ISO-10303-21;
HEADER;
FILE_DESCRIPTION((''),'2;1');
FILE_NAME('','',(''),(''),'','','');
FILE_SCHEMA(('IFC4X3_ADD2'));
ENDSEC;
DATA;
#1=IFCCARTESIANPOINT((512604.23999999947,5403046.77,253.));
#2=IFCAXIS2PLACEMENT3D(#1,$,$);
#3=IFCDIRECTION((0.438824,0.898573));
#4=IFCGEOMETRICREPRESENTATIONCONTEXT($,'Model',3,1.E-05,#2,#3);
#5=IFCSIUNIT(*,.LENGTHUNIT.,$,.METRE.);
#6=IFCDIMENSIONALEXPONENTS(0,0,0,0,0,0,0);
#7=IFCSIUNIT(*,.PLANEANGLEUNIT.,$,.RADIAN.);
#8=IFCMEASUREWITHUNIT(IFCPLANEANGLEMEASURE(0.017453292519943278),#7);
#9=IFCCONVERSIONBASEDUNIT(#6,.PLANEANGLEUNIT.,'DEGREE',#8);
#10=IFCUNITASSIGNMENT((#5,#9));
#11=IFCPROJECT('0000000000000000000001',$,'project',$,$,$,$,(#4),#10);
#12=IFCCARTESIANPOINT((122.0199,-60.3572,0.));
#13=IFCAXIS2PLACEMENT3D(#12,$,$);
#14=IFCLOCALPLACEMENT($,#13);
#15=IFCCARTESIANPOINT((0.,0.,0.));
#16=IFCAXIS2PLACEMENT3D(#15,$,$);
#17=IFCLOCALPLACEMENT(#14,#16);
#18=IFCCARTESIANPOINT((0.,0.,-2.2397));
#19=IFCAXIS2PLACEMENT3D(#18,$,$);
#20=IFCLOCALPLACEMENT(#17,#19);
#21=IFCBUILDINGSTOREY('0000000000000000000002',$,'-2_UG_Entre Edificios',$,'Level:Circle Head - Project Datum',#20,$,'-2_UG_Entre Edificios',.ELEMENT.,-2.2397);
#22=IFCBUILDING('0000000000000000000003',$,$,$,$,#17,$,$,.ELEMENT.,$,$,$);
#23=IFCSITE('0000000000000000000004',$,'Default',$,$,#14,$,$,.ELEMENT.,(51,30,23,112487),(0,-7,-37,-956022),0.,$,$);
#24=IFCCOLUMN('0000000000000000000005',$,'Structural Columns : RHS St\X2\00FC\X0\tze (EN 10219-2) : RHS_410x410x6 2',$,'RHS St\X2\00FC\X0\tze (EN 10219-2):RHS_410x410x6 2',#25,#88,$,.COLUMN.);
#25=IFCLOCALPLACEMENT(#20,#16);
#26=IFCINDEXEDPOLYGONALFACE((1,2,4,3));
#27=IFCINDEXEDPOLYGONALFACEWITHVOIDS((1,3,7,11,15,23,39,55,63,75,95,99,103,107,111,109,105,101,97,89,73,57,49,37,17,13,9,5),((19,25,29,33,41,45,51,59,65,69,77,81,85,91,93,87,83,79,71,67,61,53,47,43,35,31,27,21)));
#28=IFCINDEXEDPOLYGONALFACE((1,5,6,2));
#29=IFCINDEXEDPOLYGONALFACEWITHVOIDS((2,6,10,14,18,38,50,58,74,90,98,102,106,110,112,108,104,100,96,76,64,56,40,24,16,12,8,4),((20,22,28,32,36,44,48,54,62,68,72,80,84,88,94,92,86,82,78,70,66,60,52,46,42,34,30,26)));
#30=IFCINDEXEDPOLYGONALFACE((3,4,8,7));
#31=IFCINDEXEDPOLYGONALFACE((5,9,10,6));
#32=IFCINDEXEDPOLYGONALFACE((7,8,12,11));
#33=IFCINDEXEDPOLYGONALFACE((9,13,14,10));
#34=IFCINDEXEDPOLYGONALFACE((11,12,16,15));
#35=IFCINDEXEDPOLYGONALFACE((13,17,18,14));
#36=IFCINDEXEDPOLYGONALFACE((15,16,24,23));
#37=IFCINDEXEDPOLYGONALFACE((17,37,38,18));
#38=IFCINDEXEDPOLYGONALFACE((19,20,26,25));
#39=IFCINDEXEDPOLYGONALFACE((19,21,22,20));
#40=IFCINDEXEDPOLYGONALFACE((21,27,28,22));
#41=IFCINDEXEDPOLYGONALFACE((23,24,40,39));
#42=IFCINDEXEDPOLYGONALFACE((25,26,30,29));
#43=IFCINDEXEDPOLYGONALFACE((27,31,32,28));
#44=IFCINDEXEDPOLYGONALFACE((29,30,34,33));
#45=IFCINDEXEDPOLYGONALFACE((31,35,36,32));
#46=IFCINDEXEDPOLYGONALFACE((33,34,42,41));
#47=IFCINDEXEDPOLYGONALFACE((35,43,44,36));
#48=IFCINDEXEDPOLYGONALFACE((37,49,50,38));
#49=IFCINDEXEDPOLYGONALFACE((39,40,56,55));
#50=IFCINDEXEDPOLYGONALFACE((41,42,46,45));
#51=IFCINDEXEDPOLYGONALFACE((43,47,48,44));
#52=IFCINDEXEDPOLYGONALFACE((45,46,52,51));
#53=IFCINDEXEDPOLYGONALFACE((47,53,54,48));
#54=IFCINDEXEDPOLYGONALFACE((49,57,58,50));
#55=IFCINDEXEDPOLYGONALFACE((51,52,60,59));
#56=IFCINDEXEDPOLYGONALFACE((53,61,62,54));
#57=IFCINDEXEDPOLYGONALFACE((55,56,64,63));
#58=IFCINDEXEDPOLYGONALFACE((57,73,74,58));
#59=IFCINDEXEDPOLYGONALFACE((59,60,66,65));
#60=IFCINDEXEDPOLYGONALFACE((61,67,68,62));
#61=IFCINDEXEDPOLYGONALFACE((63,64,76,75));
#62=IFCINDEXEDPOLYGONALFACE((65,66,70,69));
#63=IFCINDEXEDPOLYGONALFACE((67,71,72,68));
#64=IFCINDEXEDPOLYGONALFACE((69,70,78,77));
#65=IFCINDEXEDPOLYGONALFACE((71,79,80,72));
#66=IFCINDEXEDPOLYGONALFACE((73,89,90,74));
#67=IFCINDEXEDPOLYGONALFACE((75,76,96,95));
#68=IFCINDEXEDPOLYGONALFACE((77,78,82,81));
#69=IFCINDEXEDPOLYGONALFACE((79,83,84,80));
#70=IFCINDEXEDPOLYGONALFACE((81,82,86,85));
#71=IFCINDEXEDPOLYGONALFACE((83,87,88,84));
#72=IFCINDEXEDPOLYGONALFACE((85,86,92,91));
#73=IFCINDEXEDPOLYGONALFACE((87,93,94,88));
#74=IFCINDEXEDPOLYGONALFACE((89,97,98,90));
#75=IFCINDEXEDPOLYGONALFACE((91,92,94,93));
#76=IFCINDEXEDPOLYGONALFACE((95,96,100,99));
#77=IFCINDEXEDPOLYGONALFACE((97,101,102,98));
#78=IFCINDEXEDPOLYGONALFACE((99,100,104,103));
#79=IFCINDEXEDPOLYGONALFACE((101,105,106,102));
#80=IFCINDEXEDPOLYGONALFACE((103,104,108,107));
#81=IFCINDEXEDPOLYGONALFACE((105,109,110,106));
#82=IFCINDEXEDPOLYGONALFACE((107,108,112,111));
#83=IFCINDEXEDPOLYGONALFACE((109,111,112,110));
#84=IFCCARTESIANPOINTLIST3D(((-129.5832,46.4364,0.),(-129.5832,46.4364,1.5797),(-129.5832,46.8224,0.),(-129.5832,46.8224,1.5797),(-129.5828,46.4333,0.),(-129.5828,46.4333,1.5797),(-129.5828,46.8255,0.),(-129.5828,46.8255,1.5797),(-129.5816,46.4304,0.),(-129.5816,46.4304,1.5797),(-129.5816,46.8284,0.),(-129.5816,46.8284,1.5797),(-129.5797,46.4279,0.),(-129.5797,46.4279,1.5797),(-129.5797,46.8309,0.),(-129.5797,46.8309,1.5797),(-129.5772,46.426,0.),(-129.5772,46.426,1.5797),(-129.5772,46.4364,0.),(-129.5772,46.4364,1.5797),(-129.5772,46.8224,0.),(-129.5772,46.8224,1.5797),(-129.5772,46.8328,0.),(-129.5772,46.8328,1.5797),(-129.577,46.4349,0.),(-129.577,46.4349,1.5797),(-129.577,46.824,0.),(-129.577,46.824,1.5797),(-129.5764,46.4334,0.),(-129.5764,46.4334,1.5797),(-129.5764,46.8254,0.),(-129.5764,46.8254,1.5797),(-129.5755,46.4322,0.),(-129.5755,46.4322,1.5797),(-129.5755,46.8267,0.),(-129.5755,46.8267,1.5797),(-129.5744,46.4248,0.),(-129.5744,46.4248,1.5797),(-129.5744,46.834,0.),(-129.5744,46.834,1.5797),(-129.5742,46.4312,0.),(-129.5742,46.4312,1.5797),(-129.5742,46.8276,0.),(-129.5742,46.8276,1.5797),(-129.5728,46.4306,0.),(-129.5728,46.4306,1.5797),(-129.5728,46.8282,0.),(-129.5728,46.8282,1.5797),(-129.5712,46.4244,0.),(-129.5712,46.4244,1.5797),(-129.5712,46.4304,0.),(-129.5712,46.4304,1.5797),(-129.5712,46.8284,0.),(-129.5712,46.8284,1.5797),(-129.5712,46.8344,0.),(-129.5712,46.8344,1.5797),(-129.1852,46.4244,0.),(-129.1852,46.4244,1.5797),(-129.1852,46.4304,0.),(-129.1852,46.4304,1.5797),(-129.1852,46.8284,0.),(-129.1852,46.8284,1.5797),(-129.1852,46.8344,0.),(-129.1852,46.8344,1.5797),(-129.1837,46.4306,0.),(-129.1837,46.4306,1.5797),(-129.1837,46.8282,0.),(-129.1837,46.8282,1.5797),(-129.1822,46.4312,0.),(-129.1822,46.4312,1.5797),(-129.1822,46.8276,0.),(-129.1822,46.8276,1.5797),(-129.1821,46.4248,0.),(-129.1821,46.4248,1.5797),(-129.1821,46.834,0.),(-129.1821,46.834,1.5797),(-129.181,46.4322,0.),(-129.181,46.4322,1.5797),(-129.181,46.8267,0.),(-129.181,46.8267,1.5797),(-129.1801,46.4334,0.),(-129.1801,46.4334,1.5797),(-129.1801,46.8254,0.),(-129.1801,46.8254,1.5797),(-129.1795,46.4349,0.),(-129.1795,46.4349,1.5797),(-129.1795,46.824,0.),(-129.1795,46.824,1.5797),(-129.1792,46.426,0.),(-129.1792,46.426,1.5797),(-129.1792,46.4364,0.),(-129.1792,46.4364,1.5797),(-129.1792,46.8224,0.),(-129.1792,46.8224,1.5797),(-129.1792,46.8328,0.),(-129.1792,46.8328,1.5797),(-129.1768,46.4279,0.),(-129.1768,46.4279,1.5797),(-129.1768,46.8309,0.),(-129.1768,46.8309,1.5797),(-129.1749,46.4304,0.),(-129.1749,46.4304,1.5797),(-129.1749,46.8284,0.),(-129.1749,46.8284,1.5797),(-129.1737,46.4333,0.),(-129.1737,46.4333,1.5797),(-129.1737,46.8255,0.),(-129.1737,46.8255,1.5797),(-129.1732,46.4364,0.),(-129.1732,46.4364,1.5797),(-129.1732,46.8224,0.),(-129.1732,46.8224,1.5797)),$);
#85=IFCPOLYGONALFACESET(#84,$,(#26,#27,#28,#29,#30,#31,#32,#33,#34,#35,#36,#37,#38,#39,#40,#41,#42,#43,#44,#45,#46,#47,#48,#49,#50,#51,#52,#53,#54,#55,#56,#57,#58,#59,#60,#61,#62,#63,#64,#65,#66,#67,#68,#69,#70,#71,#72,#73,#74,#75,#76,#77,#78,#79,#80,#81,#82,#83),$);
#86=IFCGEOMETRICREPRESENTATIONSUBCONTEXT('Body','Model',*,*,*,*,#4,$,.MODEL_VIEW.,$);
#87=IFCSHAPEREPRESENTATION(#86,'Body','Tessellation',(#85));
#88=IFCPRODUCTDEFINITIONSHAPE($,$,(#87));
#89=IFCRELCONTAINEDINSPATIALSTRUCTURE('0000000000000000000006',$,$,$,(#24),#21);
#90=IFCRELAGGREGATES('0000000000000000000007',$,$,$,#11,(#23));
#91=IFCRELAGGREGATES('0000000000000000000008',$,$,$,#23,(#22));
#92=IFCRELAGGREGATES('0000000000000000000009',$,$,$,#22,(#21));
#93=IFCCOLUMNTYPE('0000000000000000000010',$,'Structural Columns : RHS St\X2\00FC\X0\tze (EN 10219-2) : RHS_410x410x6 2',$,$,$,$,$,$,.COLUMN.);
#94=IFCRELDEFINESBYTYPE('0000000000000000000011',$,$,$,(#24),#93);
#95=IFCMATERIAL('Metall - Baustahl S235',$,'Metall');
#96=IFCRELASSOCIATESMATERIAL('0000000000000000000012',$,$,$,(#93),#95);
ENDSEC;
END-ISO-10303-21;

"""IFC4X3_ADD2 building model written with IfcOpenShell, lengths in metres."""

from ifc_helpers import new_model, entity, si_unit, converted_unit, direction, frame, frame_2d, origin, place, context, subcontext, project, spatial, polyline, circle_curve, parameter, trimmed, segment, composite_curve, outline, extrude, source, transform, mapped, material, material_profile, profile_set, type_object, type_shapes, element, save


model = new_model("IFC4X3_ADD2")

# Units and contexts
model_context = context("Model", 3, precision=1e-05, world=frame((512604.23999999947, 5403046.77, 253.0)), true_north=direction((0.438824, 0.898573)))
body_context = subcontext(model_context, "Body", "Model", "MODEL_VIEW")
ifc_project = project(units=[si_unit("LENGTHUNIT", "METRE"), converted_unit("PLANEANGLEUNIT", "DEGREE", entity("IfcPlaneAngleMeasure", 0.017453292519943278), si_unit("PLANEANGLEUNIT", "RADIAN"), dimensions=[0, 0, 0, 0, 0, 0, 0])], contexts=[model_context])

# Site, building, storey
site_placement = place(None, frame((122.0199, -60.3572, 0.0)))
site = spatial("IfcSite", under=ifc_project, at=site_placement, Name="Default", CompositionType="ELEMENT", RefLatitude=(51, 30, 23, 112487), RefLongitude=(0, -7, -37, -956022), RefElevation=0.0)
building_placement = place(site_placement, origin())
building = spatial("IfcBuilding", under=site, at=building_placement, CompositionType="ELEMENT")
storey_placement = place(building_placement, frame((0.0, 0.0, -2.2397)))
storey = spatial("IfcBuildingStorey", under=building, at=storey_placement, Name="-2_UG_Entre Edificios", ObjectType="Level:Circle Head - Project Datum", LongName="-2_UG_Entre Edificios", CompositionType="ELEMENT", Elevation=-2.2397)

# Column
ifc_material_1 = material(Name="Metall - Baustahl S235", Category="Metall")
ifc_material_profile_1 = material_profile(ifc_material_1, outline(composite_curve([segment(polyline([(-0.193, -0.205), (0.193, -0.205)]), True, "CONTINUOUS"), segment(trimmed(circle_curve(frame_2d((0.193, -0.193), x_axis=(-1.0, 0.0)), 0.012), [parameter(90.0)], [parameter(180.0)], True, "PARAMETER"), True, "CONTINUOUS"), segment(polyline([(0.205, -0.193), (0.205, 0.193)]), True, "CONTINUOUS"), segment(trimmed(circle_curve(frame_2d((0.193, 0.193), x_axis=(-1.0, 0.0)), 0.012), [parameter(180.0)], [parameter(270.0)], True, "PARAMETER"), True, "CONTINUOUS"), segment(polyline([(0.193, 0.205), (-0.193, 0.205)]), True, "CONTINUOUS"), segment(trimmed(circle_curve(frame_2d((-0.193, 0.193), x_axis=(-1.0, 0.0)), 0.012), [parameter(270.0)], [parameter(360.0)], True, "PARAMETER"), True, "CONTINUOUS"), segment(polyline([(-0.205, 0.193), (-0.205, -0.193)]), True, "CONTINUOUS"), segment(trimmed(circle_curve(frame_2d((-0.193, -0.193), x_axis=(-1.0, 0.0)), 0.012), [parameter(360.0)], [parameter(90.0)], True, "PARAMETER"), True, "CONTINUOUS")], self_intersect=False), holes=[composite_curve([segment(trimmed(circle_curve(frame_2d((-0.193, -0.193), x_axis=(-1.0, 0.0)), 0.006), [parameter(0.0)], [parameter(90.0)], True, "PARAMETER"), False, "CONTINUOUS"), segment(polyline([(-0.199, -0.193), (-0.199, 0.193)]), True, "CONTINUOUS"), segment(trimmed(circle_curve(frame_2d((-0.193, 0.193), x_axis=(-1.0, 0.0)), 0.006), [parameter(270.0)], [parameter(360.0)], True, "PARAMETER"), False, "CONTINUOUS"), segment(polyline([(-0.193, 0.199), (0.193, 0.199)]), True, "CONTINUOUS"), segment(trimmed(circle_curve(frame_2d((0.193, 0.193), x_axis=(-1.0, 0.0)), 0.006), [parameter(180.0)], [parameter(270.0)], True, "PARAMETER"), False, "CONTINUOUS"), segment(polyline([(0.199, 0.193), (0.199, -0.193)]), True, "CONTINUOUS"), segment(trimmed(circle_curve(frame_2d((0.193, -0.193), x_axis=(-1.0, 0.0)), 0.006), [parameter(90.0)], [parameter(180.0)], True, "PARAMETER"), False, "CONTINUOUS"), segment(polyline([(0.193, -0.199), (-0.193, -0.199)]), True, "CONTINUOUS")], self_intersect=False)]), Name="RHS_410x410x6 2")
ifc_profile_set_1 = profile_set([ifc_material_profile_1], Name="RHS_410x410x6 2")
column_type_1 = type_object("IfcColumnType", Name="Structural Columns : RHS Stütze (EN 10219-2) : RHS_410x410x6 2", PredefinedType="COLUMN", material=ifc_profile_set_1)
shared_shape_1 = source(origin(), body_context, "Body", "SweptSolid", [
    extrude(outline(composite_curve([segment(polyline([(-0.193, -0.205), (0.193, -0.205)]), True, "CONTINUOUS"), segment(trimmed(circle_curve(frame_2d((0.193, -0.193), x_axis=(-1.0, 0.0)), 0.012), [parameter(90.0)], [parameter(180.0)], True, "PARAMETER"), True, "CONTINUOUS"), segment(polyline([(0.205, -0.193), (0.205, 0.193)]), True, "CONTINUOUS"), segment(trimmed(circle_curve(frame_2d((0.193, 0.193), x_axis=(-1.0, 0.0)), 0.012), [parameter(180.0)], [parameter(270.0)], True, "PARAMETER"), True, "CONTINUOUS"), segment(polyline([(0.193, 0.205), (-0.193, 0.205)]), True, "CONTINUOUS"), segment(trimmed(circle_curve(frame_2d((-0.193, 0.193), x_axis=(-1.0, 0.0)), 0.012), [parameter(270.0)], [parameter(360.0)], True, "PARAMETER"), True, "CONTINUOUS"), segment(polyline([(-0.205, 0.193), (-0.205, -0.193)]), True, "CONTINUOUS"), segment(trimmed(circle_curve(frame_2d((-0.193, -0.193), x_axis=(-1.0, 0.0)), 0.012), [parameter(360.0)], [parameter(90.0)], True, "PARAMETER"), True, "CONTINUOUS")], self_intersect=False), holes=[composite_curve([segment(trimmed(circle_curve(frame_2d((-0.193, -0.193), x_axis=(-1.0, 0.0)), 0.006), [parameter(0.0)], [parameter(90.0)], True, "PARAMETER"), False, "CONTINUOUS"), segment(polyline([(-0.199, -0.193), (-0.199, 0.193)]), True, "CONTINUOUS"), segment(trimmed(circle_curve(frame_2d((-0.193, 0.193), x_axis=(-1.0, 0.0)), 0.006), [parameter(270.0)], [parameter(360.0)], True, "PARAMETER"), False, "CONTINUOUS"), segment(polyline([(-0.193, 0.199), (0.193, 0.199)]), True, "CONTINUOUS"), segment(trimmed(circle_curve(frame_2d((0.193, 0.193), x_axis=(-1.0, 0.0)), 0.006), [parameter(180.0)], [parameter(270.0)], True, "PARAMETER"), False, "CONTINUOUS"), segment(polyline([(0.199, 0.193), (0.199, -0.193)]), True, "CONTINUOUS"), segment(trimmed(circle_curve(frame_2d((0.193, -0.193), x_axis=(-1.0, 0.0)), 0.006), [parameter(90.0)], [parameter(180.0)], True, "PARAMETER"), False, "CONTINUOUS"), segment(polyline([(0.193, -0.199), (-0.193, -0.199)]), True, "CONTINUOUS")], self_intersect=False)]), frame((0.0, 0.0, -2.2397), z_axis=(0.0, 0.0, 1.0), x_axis=(-1.0, 0.0, 0.0)), (0.0, 0.0, 1.0), 1.5797),
])
type_shapes(column_type_1, [shared_shape_1])
column_1_placement = place(storey_placement, frame((-129.3782, 46.6294, 2.2397)))
element("IfcColumn", 1, at=column_1_placement, inside=storey, type_object=column_type_1, Name="Structural Columns : RHS Stütze (EN 10219-2) : RHS_410x410x6 2", ObjectType="RHS Stütze (EN 10219-2):RHS_410x410x6 2", PredefinedType="COLUMN", context=body_context, shape_type="MappedRepresentation", body=[
    mapped(shared_shape_1, transform((0.0, 0.0, 0.0), scale=1.0)),
])

save(model, "model.ifc")
